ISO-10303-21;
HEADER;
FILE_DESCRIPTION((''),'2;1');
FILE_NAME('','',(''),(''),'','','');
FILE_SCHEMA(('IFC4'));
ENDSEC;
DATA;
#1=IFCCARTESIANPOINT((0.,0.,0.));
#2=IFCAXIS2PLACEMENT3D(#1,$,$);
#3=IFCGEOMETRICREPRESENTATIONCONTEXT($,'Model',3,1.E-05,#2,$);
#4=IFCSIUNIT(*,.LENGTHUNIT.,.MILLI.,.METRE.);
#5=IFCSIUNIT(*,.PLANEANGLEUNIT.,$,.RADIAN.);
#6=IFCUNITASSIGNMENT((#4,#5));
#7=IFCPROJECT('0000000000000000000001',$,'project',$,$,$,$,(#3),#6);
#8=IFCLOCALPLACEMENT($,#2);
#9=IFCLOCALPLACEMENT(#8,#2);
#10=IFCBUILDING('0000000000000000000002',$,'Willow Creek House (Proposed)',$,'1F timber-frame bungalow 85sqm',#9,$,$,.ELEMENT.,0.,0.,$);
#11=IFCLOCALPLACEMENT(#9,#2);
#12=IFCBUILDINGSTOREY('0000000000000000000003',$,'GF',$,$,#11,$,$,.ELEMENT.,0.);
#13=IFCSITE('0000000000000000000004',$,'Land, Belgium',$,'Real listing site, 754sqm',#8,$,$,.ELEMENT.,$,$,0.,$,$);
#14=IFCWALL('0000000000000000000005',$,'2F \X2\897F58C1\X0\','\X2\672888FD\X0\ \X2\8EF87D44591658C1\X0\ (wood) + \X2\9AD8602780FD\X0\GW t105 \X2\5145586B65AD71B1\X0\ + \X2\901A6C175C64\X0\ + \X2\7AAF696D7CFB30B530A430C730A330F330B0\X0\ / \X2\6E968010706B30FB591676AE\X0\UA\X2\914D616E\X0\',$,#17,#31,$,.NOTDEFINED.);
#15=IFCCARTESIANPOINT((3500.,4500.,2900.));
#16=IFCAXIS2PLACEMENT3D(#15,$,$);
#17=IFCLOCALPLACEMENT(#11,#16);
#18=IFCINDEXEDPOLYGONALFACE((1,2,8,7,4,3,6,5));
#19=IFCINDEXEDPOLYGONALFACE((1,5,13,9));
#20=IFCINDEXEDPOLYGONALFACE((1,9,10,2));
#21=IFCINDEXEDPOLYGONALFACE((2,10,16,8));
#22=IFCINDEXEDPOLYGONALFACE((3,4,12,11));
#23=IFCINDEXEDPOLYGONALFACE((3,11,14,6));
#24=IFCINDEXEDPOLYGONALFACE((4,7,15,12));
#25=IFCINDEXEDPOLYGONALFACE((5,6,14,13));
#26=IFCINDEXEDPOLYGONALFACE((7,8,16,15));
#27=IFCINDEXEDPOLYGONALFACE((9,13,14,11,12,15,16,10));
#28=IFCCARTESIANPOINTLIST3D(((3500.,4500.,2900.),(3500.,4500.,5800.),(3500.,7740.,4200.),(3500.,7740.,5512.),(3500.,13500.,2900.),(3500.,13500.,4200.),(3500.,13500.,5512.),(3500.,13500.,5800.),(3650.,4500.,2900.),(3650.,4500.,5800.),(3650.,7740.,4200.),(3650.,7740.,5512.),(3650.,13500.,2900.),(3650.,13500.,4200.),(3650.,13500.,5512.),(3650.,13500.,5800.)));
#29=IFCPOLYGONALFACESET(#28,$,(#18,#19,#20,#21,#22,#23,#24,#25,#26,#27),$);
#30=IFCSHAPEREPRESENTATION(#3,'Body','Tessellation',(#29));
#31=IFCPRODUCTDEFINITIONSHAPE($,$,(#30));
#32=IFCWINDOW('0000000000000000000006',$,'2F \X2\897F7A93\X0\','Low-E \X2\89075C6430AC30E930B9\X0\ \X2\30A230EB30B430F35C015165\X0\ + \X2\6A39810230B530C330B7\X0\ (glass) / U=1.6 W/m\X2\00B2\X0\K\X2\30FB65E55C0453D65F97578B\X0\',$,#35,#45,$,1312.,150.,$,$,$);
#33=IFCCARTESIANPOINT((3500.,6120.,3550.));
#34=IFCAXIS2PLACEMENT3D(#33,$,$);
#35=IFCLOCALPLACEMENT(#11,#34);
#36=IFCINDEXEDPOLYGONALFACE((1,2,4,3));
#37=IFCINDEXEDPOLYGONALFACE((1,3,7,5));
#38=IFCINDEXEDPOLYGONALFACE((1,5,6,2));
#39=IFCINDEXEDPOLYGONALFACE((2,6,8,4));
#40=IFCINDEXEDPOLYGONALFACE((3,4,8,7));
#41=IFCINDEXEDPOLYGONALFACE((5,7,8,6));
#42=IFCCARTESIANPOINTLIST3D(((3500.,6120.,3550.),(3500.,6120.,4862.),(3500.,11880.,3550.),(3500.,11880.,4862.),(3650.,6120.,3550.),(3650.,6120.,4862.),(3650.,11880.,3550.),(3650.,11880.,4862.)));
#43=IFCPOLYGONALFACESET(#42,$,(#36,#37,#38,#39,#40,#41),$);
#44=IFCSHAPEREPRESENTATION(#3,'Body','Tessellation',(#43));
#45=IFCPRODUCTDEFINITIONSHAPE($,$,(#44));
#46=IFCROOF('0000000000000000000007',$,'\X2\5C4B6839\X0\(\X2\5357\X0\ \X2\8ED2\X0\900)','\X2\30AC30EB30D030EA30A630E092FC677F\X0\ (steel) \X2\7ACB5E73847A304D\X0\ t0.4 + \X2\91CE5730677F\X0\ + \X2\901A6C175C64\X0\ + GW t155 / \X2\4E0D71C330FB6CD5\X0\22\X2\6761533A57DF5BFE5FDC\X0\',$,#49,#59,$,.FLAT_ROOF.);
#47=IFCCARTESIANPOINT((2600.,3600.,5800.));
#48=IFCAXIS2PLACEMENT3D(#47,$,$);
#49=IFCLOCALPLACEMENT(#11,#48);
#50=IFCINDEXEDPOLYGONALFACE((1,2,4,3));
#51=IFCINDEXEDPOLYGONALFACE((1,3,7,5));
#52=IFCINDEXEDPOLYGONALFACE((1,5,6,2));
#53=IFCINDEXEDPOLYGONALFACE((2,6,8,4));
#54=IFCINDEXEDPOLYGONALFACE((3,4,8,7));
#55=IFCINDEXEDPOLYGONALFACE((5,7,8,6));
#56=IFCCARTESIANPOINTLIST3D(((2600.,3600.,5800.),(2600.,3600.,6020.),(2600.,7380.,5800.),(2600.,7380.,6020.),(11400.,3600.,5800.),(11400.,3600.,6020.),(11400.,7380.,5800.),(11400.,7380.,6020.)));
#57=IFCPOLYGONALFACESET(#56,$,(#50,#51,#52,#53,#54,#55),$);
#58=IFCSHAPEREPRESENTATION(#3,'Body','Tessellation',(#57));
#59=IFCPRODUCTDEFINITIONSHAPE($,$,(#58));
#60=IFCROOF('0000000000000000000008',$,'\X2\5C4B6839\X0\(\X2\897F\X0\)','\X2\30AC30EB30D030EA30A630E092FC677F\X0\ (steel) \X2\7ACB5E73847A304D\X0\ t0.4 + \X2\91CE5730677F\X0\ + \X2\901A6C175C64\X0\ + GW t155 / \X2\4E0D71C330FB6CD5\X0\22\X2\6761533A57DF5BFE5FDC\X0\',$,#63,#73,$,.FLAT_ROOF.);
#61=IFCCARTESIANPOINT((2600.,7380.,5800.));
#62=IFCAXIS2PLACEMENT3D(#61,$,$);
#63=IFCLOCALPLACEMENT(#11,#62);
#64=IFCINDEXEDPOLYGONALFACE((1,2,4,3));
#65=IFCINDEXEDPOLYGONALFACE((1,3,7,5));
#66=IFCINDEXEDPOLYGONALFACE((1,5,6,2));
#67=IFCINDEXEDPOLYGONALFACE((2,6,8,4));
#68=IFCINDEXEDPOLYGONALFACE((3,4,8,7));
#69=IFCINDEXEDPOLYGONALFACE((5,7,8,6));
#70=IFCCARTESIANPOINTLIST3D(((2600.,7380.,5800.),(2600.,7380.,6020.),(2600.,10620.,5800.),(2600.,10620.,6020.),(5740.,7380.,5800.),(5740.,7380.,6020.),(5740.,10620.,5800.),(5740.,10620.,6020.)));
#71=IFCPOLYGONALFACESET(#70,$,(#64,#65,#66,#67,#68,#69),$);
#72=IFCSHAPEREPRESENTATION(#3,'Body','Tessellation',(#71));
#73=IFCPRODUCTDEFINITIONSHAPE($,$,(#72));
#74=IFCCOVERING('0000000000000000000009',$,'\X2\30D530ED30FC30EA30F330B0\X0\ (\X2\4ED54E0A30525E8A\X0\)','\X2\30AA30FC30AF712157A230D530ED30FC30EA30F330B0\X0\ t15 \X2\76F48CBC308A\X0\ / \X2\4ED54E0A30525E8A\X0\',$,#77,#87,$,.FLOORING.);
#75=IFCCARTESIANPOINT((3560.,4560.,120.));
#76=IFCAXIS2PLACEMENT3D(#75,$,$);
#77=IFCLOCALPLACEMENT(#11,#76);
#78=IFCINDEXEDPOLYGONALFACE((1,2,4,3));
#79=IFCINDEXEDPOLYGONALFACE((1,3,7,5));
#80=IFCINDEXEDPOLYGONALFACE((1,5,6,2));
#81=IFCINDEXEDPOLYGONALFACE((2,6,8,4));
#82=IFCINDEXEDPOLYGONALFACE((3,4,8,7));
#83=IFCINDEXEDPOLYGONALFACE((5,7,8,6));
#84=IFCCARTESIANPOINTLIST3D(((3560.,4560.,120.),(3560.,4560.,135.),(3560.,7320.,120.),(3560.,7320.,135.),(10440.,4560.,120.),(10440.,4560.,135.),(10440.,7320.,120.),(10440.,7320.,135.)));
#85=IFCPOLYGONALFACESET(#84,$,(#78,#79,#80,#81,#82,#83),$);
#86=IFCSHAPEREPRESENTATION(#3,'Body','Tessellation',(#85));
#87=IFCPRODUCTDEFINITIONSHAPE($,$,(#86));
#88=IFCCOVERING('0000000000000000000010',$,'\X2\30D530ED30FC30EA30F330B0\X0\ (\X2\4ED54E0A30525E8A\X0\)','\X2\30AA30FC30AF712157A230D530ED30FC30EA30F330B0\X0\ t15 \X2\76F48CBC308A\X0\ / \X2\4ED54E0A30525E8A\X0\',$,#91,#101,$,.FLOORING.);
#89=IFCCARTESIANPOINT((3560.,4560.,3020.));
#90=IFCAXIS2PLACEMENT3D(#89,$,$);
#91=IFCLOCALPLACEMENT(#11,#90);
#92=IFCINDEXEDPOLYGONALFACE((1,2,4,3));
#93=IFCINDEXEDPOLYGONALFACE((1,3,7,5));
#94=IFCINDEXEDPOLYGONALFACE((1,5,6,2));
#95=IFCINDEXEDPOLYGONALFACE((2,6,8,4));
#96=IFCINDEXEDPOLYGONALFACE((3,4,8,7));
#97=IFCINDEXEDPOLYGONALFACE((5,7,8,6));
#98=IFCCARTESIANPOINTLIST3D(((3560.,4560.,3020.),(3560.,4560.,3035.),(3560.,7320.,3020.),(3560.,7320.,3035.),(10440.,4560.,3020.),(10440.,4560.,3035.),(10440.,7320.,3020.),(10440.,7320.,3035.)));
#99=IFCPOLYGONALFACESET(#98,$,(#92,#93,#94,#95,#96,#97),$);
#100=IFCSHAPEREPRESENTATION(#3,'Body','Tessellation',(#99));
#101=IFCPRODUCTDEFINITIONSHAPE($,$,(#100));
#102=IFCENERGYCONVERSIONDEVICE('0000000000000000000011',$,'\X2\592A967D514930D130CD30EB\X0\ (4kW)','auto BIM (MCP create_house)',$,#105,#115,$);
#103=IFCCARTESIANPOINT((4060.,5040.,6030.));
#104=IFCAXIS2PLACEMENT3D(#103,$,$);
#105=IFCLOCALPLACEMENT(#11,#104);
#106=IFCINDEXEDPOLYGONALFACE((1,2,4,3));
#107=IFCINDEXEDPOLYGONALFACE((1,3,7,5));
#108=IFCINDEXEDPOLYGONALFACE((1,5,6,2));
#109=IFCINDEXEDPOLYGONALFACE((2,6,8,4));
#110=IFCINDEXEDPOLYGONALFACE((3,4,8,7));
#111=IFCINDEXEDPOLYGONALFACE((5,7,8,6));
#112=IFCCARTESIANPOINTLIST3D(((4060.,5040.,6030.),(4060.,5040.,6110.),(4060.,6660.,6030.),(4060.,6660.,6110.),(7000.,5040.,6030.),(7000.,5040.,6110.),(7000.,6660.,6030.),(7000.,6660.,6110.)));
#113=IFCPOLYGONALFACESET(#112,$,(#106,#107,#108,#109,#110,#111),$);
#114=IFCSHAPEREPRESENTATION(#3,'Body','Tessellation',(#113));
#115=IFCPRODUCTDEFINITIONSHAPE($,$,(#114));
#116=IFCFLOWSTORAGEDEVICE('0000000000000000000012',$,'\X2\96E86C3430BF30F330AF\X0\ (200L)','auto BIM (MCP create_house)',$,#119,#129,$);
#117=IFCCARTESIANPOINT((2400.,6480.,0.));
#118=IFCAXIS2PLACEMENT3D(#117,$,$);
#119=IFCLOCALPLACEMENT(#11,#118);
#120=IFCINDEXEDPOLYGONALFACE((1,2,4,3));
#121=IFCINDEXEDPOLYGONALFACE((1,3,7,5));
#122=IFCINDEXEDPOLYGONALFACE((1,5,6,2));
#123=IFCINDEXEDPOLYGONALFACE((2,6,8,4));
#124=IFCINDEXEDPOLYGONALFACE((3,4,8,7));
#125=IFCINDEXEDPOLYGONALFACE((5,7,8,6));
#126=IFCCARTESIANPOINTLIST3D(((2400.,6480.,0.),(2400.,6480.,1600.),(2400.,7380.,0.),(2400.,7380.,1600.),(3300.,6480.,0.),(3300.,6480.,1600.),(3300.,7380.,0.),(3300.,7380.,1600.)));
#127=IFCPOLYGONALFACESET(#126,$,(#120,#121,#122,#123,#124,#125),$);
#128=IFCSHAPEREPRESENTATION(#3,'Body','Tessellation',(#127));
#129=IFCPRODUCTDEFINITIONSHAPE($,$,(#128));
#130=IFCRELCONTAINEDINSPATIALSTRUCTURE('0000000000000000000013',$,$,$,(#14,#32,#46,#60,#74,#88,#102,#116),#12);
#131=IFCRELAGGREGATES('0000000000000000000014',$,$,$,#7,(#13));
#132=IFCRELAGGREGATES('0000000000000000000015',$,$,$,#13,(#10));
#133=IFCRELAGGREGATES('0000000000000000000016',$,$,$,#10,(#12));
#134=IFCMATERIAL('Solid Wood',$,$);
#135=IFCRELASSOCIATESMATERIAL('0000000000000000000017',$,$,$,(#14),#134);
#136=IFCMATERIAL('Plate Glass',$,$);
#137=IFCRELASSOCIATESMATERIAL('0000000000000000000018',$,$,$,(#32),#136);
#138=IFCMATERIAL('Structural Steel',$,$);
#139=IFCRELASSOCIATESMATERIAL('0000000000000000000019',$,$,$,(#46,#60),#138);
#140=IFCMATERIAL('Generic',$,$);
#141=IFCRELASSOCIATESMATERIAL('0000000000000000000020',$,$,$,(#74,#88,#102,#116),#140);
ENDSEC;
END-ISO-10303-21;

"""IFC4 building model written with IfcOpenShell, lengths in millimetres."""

from ifc_helpers import new_model, si_unit, frame, frame_2d, origin, place, context, project, spatial, rectangle, extrude, material, element, fill, save


model = new_model("IFC4")

# Units and contexts
model_context = context("Model", 3, precision=1e-05, world=origin())
ifc_project = project(units=[si_unit("LENGTHUNIT", "METRE", prefix="MILLI"), si_unit("PLANEANGLEUNIT", "RADIAN")], contexts=[model_context])

# Site, building, storey
site_placement = place(None, origin())
site = spatial("IfcSite", under=ifc_project, at=site_placement, Name="Land, Belgium", ObjectType="Real listing site, 754sqm", CompositionType="ELEMENT", RefElevation=0.0)
building_placement = place(site_placement, origin())
building = spatial("IfcBuilding", under=site, at=building_placement, Name="Willow Creek House (Proposed)", ObjectType="1F timber-frame bungalow 85sqm", CompositionType="ELEMENT", ElevationOfRefHeight=0.0, ElevationOfTerrain=0.0)
storey_placement = place(building_placement, origin())
storey = spatial("IfcBuildingStorey", under=building, at=storey_placement, Name="GF", CompositionType="ELEMENT", Elevation=0.0)

# Shared definitions
ifc_material_1 = material(Name="Solid Wood")
ifc_material_2 = material(Name="Generic")

# Shared definitions
ifc_material_3 = material(Name="Plate Glass")

# Wall, opening, window
wall_1_placement = place(storey_placement, frame((3500.0, 4500.0, 2900.0)))
wall_1 = element("IfcWall", 1, at=wall_1_placement, inside=storey, material=ifc_material_1, Name="2F 西壁", Description="木製 軸組外壁 (wood) + 高性能GW t105 充填断熱 + 通気層 + 窯業系サイディング / 準耐火・外皮UA配慮", PredefinedType="NOTDEFINED", context=model_context, shape_type="SweptSolid", body=[
    extrude(rectangle(XDim=150.0, YDim=9000.0, at=frame_2d((75.0, 4500.0))), frame((3500.0, 4500.0, 2900.0)), (0.0, 0.0, 1.0), 2900.0),
])
opening_1_placement = place(storey_placement, frame((3500.0, 6120.0, 3550.0)))
opening_1 = element("IfcOpeningElement", 2, at=opening_1_placement, cuts=wall_1, PredefinedType="NOTDEFINED", context=model_context, shape_type="SweptSolid", body=[
    extrude(rectangle(XDim=150.0, YDim=5760.0, at=frame_2d((75.0, 2880.0))), frame((3500.0, 6120.0, 3550.0)), (0.0, 0.0, 1.0), 1312.0),
])
window_1_placement = place(storey_placement, frame((3500.0, 6120.0, 3550.0)))
window_1 = element("IfcWindow", 3, at=window_1_placement, inside=storey, material=ifc_material_3, Name="2F 西窓", Description="Low-E 複層ガラス アルゴン封入 + 樹脂サッシ (glass) / U=1.6 W/m²K・日射取得型", OverallHeight=1312.0, OverallWidth=150.0, context=model_context, shape_type="SweptSolid", body=[
    extrude(rectangle(XDim=150.0, YDim=5760.0, at=frame_2d((75.0, 2880.0))), frame((3500.0, 6120.0, 3550.0)), (0.0, 0.0, 1.0), 1312.0),
])
fill(opening_1, window_1)

# Roofs
ifc_material_4 = material(Name="Structural Steel")
roof_1_placement = place(storey_placement, frame((2600.0, 3600.0, 5800.0)))
element("IfcRoof", 4, at=roof_1_placement, inside=storey, material=ifc_material_4, Name="屋根(南 軒900)", Description="ガルバリウム鋼板 (steel) 立平葺き t0.4 + 野地板 + 通気層 + GW t155 / 不燃・法22条区域対応", PredefinedType="FLAT_ROOF", context=model_context, shape_type="SweptSolid", body=[
    extrude(rectangle(XDim=8800.0, YDim=3780.0, at=frame_2d((4400.0, 1890.0))), frame((2600.0, 3600.0, 5800.0)), (0.0, 0.0, 1.0), 220.0),
])
roof_2_placement = place(storey_placement, frame((2600.0, 7380.0, 5800.0)))
element("IfcRoof", 5, at=roof_2_placement, inside=storey, material=ifc_material_4, Name="屋根(西)", Description="ガルバリウム鋼板 (steel) 立平葺き t0.4 + 野地板 + 通気層 + GW t155 / 不燃・法22条区域対応", PredefinedType="FLAT_ROOF", context=model_context, shape_type="SweptSolid", body=[
    extrude(rectangle(XDim=3140.0, YDim=3240.0, at=frame_2d((1570.0, 1620.0))), frame((2600.0, 7380.0, 5800.0)), (0.0, 0.0, 1.0), 220.0),
])

# Coverings
covering_1_placement = place(storey_placement, frame((3560.0, 4560.0, 120.0)))
element("IfcCovering", 6, at=covering_1_placement, inside=storey, material=ifc_material_2, Name="フローリング (仕上げ床)", Description="オーク無垢フローリング t15 直貼り / 仕上げ床", PredefinedType="FLOORING", context=model_context, shape_type="SweptSolid", body=[
    extrude(rectangle(XDim=6880.0, YDim=2760.0, at=frame_2d((3440.0, 1380.0))), frame((3560.0, 4560.0, 120.0)), (0.0, 0.0, 1.0), 15.0),
])
covering_2_placement = place(storey_placement, frame((3560.0, 4560.0, 3020.0)))
element("IfcCovering", 7, at=covering_2_placement, inside=storey, material=ifc_material_2, Name="フローリング (仕上げ床)", Description="オーク無垢フローリング t15 直貼り / 仕上げ床", PredefinedType="FLOORING", context=model_context, shape_type="SweptSolid", body=[
    extrude(rectangle(XDim=6880.0, YDim=2760.0, at=frame_2d((3440.0, 1380.0))), frame((3560.0, 4560.0, 3020.0)), (0.0, 0.0, 1.0), 15.0),
])

# Energy conversion device
energy_conversion_device_placement = place(storey_placement, frame((4060.0, 5040.0, 6030.0)))
element("IfcEnergyConversionDevice", 8, at=energy_conversion_device_placement, inside=storey, material=ifc_material_2, Name="太陽光パネル (4kW)", Description="auto BIM (MCP create_house)", context=model_context, shape_type="SweptSolid", body=[
    extrude(rectangle(XDim=2940.0, YDim=1620.0, at=frame_2d((1470.0, 810.0))), frame((4060.0, 5040.0, 6030.0)), (0.0, 0.0, 1.0), 80.0),
])

# Flow storage device
flow_storage_device_placement = place(storey_placement, frame((2400.0, 6480.0, 0.0)))
element("IfcFlowStorageDevice", 9, at=flow_storage_device_placement, inside=storey, material=ifc_material_2, Name="雨水タンク (200L)", Description="auto BIM (MCP create_house)", context=model_context, shape_type="SweptSolid", body=[
    extrude(rectangle(XDim=900.0, YDim=900.0, at=frame_2d((450.0, 450.0))), frame((2400.0, 6480.0, 0.0)), (0.0, 0.0, 1.0), 1600.0),
])

save(model, "model.ifc")
